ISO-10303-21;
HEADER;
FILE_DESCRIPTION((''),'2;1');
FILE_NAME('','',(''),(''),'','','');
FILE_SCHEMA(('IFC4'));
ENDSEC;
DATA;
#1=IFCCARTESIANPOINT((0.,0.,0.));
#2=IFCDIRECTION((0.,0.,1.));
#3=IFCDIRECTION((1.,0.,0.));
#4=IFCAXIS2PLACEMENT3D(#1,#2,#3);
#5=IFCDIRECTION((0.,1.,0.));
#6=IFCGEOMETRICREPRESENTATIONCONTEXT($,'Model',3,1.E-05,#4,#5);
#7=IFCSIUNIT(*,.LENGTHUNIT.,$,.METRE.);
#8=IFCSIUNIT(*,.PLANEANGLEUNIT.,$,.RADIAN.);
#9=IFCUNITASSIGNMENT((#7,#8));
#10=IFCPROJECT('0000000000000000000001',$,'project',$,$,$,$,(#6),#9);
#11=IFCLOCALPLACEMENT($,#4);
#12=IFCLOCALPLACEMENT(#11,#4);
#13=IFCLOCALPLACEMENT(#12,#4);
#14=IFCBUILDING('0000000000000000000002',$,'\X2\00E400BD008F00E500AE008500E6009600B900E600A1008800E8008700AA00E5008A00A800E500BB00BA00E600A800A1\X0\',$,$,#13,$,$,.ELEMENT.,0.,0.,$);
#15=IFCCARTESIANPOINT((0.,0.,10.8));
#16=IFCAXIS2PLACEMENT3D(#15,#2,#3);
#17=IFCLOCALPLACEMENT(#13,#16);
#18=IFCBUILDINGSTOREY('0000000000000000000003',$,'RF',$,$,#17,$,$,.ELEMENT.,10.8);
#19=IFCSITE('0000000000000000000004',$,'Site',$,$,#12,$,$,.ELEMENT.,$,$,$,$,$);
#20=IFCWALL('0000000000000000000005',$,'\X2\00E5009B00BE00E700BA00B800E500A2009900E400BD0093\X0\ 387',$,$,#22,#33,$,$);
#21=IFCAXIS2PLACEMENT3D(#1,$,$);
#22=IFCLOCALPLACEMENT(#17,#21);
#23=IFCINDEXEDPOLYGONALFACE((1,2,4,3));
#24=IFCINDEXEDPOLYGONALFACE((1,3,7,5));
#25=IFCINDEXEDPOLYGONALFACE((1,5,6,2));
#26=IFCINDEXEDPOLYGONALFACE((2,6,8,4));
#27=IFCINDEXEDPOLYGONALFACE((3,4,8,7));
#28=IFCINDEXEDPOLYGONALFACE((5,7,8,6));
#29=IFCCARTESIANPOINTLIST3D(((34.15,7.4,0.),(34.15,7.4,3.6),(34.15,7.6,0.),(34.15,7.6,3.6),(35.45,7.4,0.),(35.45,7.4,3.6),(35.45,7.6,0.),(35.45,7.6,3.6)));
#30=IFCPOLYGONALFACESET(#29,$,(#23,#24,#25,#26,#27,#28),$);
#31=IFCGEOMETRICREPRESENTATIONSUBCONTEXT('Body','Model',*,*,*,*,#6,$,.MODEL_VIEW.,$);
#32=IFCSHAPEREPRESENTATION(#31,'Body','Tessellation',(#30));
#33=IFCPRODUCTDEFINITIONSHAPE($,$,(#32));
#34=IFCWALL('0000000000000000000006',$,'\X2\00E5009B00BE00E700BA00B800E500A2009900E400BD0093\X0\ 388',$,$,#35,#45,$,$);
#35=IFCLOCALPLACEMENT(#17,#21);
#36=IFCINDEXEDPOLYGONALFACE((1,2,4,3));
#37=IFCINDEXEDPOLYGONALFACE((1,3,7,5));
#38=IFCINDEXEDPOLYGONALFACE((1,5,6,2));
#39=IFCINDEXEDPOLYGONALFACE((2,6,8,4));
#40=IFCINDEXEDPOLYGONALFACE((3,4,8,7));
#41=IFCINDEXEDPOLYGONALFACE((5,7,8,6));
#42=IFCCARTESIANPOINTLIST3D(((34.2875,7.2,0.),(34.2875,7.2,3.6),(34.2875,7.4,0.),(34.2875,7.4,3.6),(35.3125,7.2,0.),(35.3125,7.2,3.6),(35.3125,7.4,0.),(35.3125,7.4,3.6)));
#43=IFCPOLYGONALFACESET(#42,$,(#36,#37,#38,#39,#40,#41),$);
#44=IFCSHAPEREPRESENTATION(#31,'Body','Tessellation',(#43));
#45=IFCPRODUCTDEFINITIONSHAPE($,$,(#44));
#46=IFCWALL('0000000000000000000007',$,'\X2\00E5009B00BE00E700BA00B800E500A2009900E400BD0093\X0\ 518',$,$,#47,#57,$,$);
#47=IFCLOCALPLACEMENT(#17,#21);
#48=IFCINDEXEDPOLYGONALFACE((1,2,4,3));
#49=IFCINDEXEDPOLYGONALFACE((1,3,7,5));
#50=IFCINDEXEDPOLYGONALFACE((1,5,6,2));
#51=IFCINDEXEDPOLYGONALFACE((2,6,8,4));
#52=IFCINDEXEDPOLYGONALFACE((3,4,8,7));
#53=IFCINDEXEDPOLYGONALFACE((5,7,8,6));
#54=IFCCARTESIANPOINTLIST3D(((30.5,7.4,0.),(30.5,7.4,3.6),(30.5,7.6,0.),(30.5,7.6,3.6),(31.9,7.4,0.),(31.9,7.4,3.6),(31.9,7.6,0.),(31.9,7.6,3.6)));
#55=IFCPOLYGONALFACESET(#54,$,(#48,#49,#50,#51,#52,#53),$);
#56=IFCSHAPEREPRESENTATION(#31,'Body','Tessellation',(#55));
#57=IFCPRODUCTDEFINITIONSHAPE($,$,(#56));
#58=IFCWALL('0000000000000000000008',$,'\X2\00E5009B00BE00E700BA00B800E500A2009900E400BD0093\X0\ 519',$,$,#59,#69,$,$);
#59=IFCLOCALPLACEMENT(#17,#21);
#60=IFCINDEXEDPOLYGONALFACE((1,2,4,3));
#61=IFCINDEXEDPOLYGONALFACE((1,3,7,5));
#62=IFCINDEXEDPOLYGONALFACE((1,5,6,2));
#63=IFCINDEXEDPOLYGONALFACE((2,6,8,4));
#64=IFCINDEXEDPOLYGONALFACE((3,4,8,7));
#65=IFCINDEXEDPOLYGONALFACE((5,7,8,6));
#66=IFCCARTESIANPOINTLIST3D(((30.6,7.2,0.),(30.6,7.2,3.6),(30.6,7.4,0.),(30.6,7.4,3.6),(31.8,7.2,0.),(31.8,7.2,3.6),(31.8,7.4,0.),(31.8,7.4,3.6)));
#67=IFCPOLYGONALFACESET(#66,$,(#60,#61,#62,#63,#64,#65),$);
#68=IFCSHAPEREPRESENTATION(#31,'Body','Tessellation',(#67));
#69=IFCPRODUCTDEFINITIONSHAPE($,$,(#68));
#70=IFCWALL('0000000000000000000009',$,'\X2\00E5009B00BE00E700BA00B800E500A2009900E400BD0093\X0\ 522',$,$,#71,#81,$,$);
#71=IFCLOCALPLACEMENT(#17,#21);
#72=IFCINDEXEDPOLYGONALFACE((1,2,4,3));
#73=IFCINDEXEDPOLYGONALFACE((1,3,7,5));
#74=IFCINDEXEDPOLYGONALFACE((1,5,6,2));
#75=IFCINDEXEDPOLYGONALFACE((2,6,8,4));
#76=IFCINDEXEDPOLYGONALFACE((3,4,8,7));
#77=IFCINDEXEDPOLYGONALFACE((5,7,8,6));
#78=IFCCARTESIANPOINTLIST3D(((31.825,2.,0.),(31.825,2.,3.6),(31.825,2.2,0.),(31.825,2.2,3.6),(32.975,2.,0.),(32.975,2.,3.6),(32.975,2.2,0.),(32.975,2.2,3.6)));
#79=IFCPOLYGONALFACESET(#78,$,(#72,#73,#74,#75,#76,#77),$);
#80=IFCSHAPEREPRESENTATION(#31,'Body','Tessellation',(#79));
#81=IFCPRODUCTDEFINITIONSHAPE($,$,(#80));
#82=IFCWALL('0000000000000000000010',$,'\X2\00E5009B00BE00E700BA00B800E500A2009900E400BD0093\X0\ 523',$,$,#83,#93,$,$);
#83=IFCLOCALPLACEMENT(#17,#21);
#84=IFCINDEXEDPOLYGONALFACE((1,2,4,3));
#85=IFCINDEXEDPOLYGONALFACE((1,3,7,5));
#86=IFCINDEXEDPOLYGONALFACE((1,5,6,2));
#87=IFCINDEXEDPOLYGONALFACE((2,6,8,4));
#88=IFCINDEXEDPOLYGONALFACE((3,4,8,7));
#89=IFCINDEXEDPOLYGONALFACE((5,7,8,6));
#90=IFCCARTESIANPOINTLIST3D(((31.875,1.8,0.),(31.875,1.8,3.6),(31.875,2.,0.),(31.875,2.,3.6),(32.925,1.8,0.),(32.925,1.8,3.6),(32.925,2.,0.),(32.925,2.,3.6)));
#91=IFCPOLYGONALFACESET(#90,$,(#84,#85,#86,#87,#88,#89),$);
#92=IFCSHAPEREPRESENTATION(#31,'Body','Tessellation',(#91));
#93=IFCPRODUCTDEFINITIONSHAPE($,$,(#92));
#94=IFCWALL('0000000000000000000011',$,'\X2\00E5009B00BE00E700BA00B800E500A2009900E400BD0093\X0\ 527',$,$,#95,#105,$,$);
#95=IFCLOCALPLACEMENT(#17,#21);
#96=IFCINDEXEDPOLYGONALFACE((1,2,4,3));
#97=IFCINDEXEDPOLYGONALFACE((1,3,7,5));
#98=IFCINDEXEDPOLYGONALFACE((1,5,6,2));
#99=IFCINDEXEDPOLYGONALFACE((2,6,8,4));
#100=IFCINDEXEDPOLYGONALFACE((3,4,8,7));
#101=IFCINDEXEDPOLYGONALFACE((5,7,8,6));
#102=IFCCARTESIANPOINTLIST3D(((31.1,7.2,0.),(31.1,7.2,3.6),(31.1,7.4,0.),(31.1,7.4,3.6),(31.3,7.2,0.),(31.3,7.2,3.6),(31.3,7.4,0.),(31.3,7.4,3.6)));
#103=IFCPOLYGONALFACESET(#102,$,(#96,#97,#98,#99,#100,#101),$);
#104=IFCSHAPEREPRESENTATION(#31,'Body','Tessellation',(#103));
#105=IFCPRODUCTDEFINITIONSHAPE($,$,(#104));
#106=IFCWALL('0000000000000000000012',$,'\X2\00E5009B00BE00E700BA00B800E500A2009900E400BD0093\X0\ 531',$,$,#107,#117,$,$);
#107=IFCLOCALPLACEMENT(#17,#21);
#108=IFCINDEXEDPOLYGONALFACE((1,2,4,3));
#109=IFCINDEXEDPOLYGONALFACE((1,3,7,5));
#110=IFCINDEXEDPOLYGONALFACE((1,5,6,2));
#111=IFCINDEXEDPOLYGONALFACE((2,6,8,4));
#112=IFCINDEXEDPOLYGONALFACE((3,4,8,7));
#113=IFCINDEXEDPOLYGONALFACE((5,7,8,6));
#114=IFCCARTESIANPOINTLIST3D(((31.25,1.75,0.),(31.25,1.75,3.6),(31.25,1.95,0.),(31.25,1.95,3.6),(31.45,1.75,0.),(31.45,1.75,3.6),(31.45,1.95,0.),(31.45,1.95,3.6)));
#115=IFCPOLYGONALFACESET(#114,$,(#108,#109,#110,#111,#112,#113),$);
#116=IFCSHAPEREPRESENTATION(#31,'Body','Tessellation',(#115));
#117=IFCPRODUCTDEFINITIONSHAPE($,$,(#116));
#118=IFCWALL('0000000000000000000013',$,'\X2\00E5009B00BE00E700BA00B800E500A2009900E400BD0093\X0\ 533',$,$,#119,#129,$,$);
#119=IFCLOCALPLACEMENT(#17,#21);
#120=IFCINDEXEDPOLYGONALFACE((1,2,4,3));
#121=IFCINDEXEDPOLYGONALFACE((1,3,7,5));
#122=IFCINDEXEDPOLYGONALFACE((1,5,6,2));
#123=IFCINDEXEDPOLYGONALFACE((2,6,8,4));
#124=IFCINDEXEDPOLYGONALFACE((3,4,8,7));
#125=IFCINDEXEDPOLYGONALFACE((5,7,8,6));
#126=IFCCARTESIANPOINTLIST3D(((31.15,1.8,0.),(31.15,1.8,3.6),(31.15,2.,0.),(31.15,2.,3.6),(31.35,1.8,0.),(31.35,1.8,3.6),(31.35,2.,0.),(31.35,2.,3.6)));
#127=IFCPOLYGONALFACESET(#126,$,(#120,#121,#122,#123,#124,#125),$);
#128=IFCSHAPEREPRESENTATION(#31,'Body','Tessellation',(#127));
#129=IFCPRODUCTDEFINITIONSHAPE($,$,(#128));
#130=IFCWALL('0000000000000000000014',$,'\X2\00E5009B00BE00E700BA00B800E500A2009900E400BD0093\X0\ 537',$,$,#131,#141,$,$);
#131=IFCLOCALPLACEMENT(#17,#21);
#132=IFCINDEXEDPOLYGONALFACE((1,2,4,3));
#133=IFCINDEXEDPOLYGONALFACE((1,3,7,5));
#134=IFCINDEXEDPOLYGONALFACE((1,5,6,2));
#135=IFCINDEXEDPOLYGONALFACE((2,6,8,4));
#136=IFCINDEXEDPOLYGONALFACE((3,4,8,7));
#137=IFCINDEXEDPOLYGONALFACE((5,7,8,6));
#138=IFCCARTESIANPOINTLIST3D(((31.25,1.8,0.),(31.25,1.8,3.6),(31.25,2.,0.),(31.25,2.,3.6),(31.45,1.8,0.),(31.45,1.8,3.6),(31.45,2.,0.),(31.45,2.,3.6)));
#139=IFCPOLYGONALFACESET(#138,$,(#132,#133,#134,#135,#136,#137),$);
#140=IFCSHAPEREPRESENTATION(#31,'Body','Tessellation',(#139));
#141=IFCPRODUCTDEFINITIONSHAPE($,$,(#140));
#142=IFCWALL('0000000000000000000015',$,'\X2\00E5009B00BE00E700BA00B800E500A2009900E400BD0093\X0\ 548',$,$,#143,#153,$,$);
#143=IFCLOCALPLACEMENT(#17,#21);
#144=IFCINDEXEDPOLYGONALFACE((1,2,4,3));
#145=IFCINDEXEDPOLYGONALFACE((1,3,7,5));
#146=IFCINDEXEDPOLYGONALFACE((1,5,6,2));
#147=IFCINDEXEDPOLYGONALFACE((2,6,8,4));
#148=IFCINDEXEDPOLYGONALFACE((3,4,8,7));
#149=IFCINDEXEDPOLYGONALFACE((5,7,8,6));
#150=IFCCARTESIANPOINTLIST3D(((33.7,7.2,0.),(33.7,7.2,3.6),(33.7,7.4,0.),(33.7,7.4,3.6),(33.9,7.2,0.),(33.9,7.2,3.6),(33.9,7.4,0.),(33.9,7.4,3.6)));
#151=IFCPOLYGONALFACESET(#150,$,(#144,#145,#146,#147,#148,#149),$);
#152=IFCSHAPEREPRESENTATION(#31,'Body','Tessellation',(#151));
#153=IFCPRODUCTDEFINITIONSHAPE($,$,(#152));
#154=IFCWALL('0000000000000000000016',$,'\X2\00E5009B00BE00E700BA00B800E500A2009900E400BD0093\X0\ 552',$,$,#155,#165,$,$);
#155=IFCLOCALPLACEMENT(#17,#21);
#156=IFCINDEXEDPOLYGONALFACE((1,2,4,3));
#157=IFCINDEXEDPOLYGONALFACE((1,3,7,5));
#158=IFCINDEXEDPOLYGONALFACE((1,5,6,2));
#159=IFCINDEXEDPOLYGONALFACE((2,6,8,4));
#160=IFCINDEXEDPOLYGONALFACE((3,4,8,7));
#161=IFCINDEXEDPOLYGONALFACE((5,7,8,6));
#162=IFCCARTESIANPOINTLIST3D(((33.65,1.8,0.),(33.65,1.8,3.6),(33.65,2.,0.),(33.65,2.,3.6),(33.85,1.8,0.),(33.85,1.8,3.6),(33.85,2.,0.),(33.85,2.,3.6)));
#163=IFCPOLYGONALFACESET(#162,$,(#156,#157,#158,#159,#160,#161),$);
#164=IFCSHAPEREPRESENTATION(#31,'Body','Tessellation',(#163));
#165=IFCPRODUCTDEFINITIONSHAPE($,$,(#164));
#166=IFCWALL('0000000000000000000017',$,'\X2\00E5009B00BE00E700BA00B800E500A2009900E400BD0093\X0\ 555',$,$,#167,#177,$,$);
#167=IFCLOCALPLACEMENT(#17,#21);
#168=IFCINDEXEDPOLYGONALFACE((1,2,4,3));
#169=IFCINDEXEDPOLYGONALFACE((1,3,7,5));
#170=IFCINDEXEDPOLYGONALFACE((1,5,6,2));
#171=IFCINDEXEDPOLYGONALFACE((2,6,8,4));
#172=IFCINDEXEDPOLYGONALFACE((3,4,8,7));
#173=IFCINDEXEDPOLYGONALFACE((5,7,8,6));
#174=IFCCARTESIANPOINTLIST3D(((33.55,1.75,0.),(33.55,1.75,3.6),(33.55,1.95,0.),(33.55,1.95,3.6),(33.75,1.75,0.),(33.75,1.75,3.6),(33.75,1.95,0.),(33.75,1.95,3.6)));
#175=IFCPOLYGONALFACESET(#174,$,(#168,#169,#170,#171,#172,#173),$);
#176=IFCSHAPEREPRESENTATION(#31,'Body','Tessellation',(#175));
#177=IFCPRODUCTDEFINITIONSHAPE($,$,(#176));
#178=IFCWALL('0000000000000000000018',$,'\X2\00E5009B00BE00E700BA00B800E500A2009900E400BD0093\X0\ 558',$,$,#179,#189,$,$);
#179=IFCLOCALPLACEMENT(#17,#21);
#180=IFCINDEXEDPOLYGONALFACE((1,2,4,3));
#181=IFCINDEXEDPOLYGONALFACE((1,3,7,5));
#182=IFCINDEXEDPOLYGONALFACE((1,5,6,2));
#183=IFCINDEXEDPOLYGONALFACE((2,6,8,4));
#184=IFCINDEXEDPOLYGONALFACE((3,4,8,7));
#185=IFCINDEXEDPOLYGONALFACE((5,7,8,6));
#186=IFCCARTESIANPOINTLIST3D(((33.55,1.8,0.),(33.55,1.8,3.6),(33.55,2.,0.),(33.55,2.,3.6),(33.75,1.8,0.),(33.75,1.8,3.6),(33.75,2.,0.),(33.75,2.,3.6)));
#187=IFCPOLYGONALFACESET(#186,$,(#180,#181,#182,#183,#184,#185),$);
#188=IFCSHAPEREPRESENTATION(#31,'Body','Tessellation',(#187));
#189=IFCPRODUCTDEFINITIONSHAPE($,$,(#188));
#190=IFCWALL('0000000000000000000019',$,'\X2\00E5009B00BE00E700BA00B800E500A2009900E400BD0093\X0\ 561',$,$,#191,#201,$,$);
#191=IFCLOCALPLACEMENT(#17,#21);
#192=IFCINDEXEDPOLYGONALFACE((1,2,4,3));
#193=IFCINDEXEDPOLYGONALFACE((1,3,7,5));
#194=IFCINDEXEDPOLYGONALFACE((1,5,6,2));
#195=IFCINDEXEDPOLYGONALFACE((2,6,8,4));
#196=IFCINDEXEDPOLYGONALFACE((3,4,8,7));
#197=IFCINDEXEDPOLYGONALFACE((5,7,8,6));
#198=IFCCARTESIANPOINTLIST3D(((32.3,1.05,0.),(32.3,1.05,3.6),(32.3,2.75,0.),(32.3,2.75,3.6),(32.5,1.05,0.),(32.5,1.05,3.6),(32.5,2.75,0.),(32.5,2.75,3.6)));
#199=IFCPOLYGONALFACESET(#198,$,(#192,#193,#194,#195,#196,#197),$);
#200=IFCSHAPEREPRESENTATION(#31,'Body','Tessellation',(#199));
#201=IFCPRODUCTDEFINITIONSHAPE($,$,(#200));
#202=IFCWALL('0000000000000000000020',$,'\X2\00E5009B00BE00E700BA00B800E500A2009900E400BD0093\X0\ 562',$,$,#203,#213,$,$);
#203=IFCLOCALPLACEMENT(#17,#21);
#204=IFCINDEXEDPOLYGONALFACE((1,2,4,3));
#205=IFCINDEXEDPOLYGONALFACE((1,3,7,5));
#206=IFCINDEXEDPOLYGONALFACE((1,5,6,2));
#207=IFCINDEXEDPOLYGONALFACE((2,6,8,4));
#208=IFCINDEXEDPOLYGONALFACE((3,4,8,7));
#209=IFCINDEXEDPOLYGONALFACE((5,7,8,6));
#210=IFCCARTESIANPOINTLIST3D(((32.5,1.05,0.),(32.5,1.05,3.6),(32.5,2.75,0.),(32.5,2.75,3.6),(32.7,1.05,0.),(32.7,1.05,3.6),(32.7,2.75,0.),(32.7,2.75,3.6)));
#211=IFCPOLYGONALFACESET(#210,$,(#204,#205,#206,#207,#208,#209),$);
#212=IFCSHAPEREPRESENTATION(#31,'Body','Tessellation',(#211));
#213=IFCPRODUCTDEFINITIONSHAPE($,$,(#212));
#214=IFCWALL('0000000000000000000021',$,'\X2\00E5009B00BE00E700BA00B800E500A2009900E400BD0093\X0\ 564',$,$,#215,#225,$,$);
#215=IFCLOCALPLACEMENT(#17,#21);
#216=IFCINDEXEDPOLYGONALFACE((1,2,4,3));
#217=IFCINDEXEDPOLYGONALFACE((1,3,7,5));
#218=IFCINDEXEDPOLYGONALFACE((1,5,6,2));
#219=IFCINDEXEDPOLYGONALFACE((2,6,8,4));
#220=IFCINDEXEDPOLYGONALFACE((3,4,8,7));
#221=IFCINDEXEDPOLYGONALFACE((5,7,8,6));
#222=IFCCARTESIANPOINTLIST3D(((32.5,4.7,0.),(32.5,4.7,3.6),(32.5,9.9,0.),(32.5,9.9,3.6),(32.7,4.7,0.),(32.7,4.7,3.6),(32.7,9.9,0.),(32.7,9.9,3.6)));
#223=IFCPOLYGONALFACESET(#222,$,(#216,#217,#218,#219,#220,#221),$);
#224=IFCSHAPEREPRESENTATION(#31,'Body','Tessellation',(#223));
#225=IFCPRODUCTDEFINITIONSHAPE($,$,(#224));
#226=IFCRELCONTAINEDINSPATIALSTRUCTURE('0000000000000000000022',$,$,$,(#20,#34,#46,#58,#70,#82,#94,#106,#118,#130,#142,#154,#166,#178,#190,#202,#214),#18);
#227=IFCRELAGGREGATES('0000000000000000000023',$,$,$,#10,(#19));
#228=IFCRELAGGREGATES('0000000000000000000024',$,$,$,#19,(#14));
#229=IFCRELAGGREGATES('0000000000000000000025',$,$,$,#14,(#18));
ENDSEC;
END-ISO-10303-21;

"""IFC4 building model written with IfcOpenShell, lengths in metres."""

from ifc_helpers import new_model, si_unit, direction, frame, frame_2d, origin_with_axes, place, context, subcontext, project, spatial, rectangle, extrude, element, save


model = new_model("IFC4")

# Units and contexts
model_context = context("Model", 3, precision=1e-05, world=origin_with_axes(), true_north=direction((0.0, 1.0, 0.0)))
body_context = subcontext(model_context, "Body", "Model", "MODEL_VIEW")
ifc_project = project(units=[si_unit("LENGTHUNIT", "METRE"), si_unit("PLANEANGLEUNIT", "RADIAN")], contexts=[model_context])

# Site, building, storey
placement = place(None, origin_with_axes())
site_placement = place(placement, origin_with_axes())
site = spatial("IfcSite", under=ifc_project, at=site_placement, Name="Site", CompositionType="ELEMENT")
building_placement = place(site_placement, origin_with_axes())
building = spatial("IfcBuilding", under=site, at=building_placement, Name="ä½\u008få®\u0085æ\u0096¹æ¡\u0088è\u0087ªå\u008a¨å»ºæ¨¡", CompositionType="ELEMENT", ElevationOfRefHeight=0.0, ElevationOfTerrain=0.0)
storey_placement = place(building_placement, frame((0.0, 0.0, 10.8), z_axis=(0.0, 0.0, 1.0), x_axis=(1.0, 0.0, 0.0)))
storey = spatial("IfcBuildingStorey", under=building, at=storey_placement, Name="RF", CompositionType="ELEMENT", Elevation=10.8)

# Walls
wall_1_placement = place(storey_placement, frame((34.8, 7.5, 0.0), z_axis=(0.0, 0.0, 1.0), x_axis=(1.0, 0.0, 0.0)))
element("IfcWall", 1, at=wall_1_placement, inside=storey, Name="å\u009b¾çº¸å¢\u0099ä½\u0093 387", context=body_context, shape_type="SweptSolid", body=[
    extrude(rectangle(XDim=1.3, YDim=0.2, at=frame_2d((0.0, 0.0), x_axis=(1.0, 0.0, 0.0))), frame((0.0, 0.0, 0.0), z_axis=(0.0, 0.0, 1.0)), (0.0, 0.0, 1.0), 3.6),
])
wall_2_placement = place(storey_placement, frame((34.8, 7.3, 0.0), z_axis=(0.0, 0.0, 1.0), x_axis=(1.0, 0.0, 0.0)))
element("IfcWall", 2, at=wall_2_placement, inside=storey, Name="å\u009b¾çº¸å¢\u0099ä½\u0093 388", context=body_context, shape_type="SweptSolid", body=[
    extrude(rectangle(XDim=1.025, YDim=0.2, at=frame_2d((0.0, 0.0), x_axis=(1.0, 0.0, 0.0))), frame((0.0, 0.0, 0.0), z_axis=(0.0, 0.0, 1.0)), (0.0, 0.0, 1.0), 3.6),
])
wall_3_placement = place(storey_placement, frame((31.2, 7.5, 0.0), z_axis=(0.0, 0.0, 1.0), x_axis=(1.0, 0.0, 0.0)))
element("IfcWall", 3, at=wall_3_placement, inside=storey, Name="å\u009b¾çº¸å¢\u0099ä½\u0093 518", context=body_context, shape_type="SweptSolid", body=[
    extrude(rectangle(XDim=1.4, YDim=0.2, at=frame_2d((0.0, 0.0), x_axis=(1.0, 0.0, 0.0))), frame((0.0, 0.0, 0.0), z_axis=(0.0, 0.0, 1.0)), (0.0, 0.0, 1.0), 3.6),
])
wall_4_placement = place(storey_placement, frame((31.2, 7.3, 0.0), z_axis=(0.0, 0.0, 1.0), x_axis=(1.0, 0.0, 0.0)))
element("IfcWall", 4, at=wall_4_placement, inside=storey, Name="å\u009b¾çº¸å¢\u0099ä½\u0093 519", context=body_context, shape_type="SweptSolid", body=[
    extrude(rectangle(XDim=1.2, YDim=0.2, at=frame_2d((0.0, 0.0), x_axis=(1.0, 0.0, 0.0))), frame((0.0, 0.0, 0.0), z_axis=(0.0, 0.0, 1.0)), (0.0, 0.0, 1.0), 3.6),
])
wall_5_placement = place(storey_placement, frame((32.4, 2.1, 0.0), z_axis=(0.0, 0.0, 1.0), x_axis=(-1.0, 0.0, 0.0)))
element("IfcWall", 5, at=wall_5_placement, inside=storey, Name="å\u009b¾çº¸å¢\u0099ä½\u0093 522", context=body_context, shape_type="SweptSolid", body=[
    extrude(rectangle(XDim=1.15, YDim=0.2, at=frame_2d((0.0, 0.0), x_axis=(1.0, 0.0, 0.0))), frame((0.0, 0.0, 0.0), z_axis=(0.0, 0.0, 1.0)), (0.0, 0.0, 1.0), 3.6),
])
wall_6_placement = place(storey_placement, frame((32.4, 1.9, 0.0), z_axis=(0.0, 0.0, 1.0), x_axis=(-1.0, 0.0, 0.0)))
element("IfcWall", 6, at=wall_6_placement, inside=storey, Name="å\u009b¾çº¸å¢\u0099ä½\u0093 523", context=body_context, shape_type="SweptSolid", body=[
    extrude(rectangle(XDim=1.05, YDim=0.2, at=frame_2d((0.0, 0.0), x_axis=(1.0, 0.0, 0.0))), frame((0.0, 0.0, 0.0), z_axis=(0.0, 0.0, 1.0)), (0.0, 0.0, 1.0), 3.6),
])
for number, where, z_axis, x_axis, name in (
    (7, (31.2, 7.3, 0.0), (0.0, 0.0, 1.0), (0.0, 1.0, 0.0), "å\u009b¾çº¸å¢\u0099ä½\u0093 527"),
    (8, (31.35, 1.85, 0.0), (0.0, 0.0, 1.0), (-1.0, 0.0, 0.0), "å\u009b¾çº¸å¢\u0099ä½\u0093 531"),
    (9, (31.25, 1.9, 0.0), (0.0, 0.0, 1.0), (0.0, 1.0, 0.0), "å\u009b¾çº¸å¢\u0099ä½\u0093 533"),
    (10, (31.35, 1.9, 0.0), (0.0, 0.0, 1.0), (0.0, -1.0, 0.0), "å\u009b¾çº¸å¢\u0099ä½\u0093 537"),
    (11, (33.8, 7.3, 0.0), (0.0, 0.0, 1.0), (0.0, 1.0, 0.0), "å\u009b¾çº¸å¢\u0099ä½\u0093 548"),
    (12, (33.75, 1.9, 0.0), (0.0, 0.0, 1.0), (0.0, 1.0, 0.0), "å\u009b¾çº¸å¢\u0099ä½\u0093 552"),
    (13, (33.65, 1.85, 0.0), (0.0, 0.0, 1.0), (1.0, 0.0, 0.0), "å\u009b¾çº¸å¢\u0099ä½\u0093 555"),
    (14, (33.65, 1.9, 0.0), (0.0, 0.0, 1.0), (0.0, -1.0, 0.0), "å\u009b¾çº¸å¢\u0099ä½\u0093 558"),
):
    element("IfcWall", number, at=place(storey_placement, frame(where, z_axis=z_axis, x_axis=x_axis)), inside=storey, Name=name, context=body_context, shape_type="SweptSolid", body=[
        extrude(rectangle(XDim=0.2, YDim=0.2, at=frame_2d((0.0, 0.0), x_axis=(1.0, 0.0, 0.0))), frame((0.0, 0.0, 0.0), z_axis=(0.0, 0.0, 1.0)), (0.0, 0.0, 1.0), 3.6),
    ])
for number, where, z_axis, x_axis, name in (
    (15, (32.4, 1.9, 0.0), (0.0, 0.0, 1.0), (0.0, -1.0, 0.0), "å\u009b¾çº¸å¢\u0099ä½\u0093 561"),
    (16, (32.6, 1.9, 0.0), (0.0, 0.0, 1.0), (0.0, -1.0, 0.0), "å\u009b¾çº¸å¢\u0099ä½\u0093 562"),
):
    element("IfcWall", number, at=place(storey_placement, frame(where, z_axis=z_axis, x_axis=x_axis)), inside=storey, Name=name, context=body_context, shape_type="SweptSolid", body=[
        extrude(rectangle(XDim=1.7, YDim=0.2, at=frame_2d((0.0, 0.0), x_axis=(1.0, 0.0, 0.0))), frame((0.0, 0.0, 0.0), z_axis=(0.0, 0.0, 1.0)), (0.0, 0.0, 1.0), 3.6),
    ])
for number, where, z_axis, x_axis, name in (
    (17, (32.6, 7.3, 0.0), (0.0, 0.0, 1.0), (0.0, -1.0, 0.0), "å\u009b¾çº¸å¢\u0099ä½\u0093 564"),
):
    element("IfcWall", number, at=place(storey_placement, frame(where, z_axis=z_axis, x_axis=x_axis)), inside=storey, Name=name, context=body_context, shape_type="SweptSolid", body=[
        extrude(rectangle(XDim=5.2, YDim=0.2, at=frame_2d((0.0, 0.0), x_axis=(1.0, 0.0, 0.0))), frame((0.0, 0.0, 0.0), z_axis=(0.0, 0.0, 1.0)), (0.0, 0.0, 1.0), 3.6),
    ])

save(model, "model.ifc")
